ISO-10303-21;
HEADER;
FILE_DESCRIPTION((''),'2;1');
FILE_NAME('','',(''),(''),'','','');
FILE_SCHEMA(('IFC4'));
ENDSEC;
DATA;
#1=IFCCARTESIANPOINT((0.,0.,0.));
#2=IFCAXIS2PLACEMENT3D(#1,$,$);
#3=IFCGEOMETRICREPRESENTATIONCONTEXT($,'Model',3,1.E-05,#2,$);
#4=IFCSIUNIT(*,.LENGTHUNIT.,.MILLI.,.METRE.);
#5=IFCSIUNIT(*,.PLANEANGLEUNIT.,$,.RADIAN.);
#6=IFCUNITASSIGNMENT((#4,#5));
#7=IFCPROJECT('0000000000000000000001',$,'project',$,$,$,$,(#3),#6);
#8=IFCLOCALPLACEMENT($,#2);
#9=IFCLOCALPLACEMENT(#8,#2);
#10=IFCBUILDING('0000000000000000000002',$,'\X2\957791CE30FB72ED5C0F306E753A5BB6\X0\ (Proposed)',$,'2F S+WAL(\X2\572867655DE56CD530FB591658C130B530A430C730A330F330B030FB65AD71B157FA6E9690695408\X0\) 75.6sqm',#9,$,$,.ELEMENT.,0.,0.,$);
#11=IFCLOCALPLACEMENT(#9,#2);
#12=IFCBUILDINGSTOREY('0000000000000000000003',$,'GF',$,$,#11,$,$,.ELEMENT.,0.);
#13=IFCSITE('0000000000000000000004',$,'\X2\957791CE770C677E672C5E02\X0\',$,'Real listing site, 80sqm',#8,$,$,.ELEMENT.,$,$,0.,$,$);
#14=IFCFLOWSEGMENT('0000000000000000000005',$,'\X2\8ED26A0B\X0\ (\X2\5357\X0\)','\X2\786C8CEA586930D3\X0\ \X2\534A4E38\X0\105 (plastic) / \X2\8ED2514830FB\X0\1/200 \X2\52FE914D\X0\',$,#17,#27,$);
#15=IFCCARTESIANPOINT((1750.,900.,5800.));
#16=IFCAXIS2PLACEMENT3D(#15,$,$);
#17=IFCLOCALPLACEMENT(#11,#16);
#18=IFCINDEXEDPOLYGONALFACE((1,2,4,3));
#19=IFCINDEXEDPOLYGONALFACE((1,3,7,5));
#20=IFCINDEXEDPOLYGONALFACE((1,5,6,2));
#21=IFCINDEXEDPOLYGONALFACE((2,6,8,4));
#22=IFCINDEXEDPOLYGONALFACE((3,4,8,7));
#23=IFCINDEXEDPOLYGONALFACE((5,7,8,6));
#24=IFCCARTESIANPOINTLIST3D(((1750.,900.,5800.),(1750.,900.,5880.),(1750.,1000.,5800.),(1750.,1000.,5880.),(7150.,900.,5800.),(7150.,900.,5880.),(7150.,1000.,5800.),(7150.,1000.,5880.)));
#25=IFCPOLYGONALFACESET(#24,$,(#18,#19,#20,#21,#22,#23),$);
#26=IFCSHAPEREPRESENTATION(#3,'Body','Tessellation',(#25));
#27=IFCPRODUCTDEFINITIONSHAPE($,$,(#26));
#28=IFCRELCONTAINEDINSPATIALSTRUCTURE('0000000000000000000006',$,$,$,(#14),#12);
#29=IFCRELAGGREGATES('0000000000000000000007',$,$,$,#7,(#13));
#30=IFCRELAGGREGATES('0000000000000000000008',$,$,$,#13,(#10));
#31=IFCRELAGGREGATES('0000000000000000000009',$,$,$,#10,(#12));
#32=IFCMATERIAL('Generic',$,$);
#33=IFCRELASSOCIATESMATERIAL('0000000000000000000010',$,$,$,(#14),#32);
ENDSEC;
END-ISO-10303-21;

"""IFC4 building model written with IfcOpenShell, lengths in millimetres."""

from ifc_helpers import new_model, si_unit, frame, frame_2d, origin, place, context, project, spatial, rectangle, extrude, material, element, save


model = new_model("IFC4")

# Units and contexts
model_context = context("Model", 3, precision=1e-05, world=origin())
ifc_project = project(units=[si_unit("LENGTHUNIT", "METRE", prefix="MILLI"), si_unit("PLANEANGLEUNIT", "RADIAN")], contexts=[model_context])

# Site, building, storey
site_placement = place(None, origin())
site = spatial("IfcSite", under=ifc_project, at=site_placement, Name="長野県松本市", ObjectType="Real listing site, 80sqm", CompositionType="ELEMENT", RefElevation=0.0)
building_placement = place(site_placement, origin())
building = spatial("IfcBuilding", under=site, at=building_placement, Name="長野・狭小の町家 (Proposed)", ObjectType="2F S+WAL(在来工法・外壁サイディング・断熱基準適合) 75.6sqm", CompositionType="ELEMENT", ElevationOfRefHeight=0.0, ElevationOfTerrain=0.0)
storey_placement = place(building_placement, origin())
storey = spatial("IfcBuildingStorey", under=building, at=storey_placement, Name="GF", CompositionType="ELEMENT", Elevation=0.0)

# Flow segment
ifc_material_1 = material(Name="Generic")
flow_segment_placement = place(storey_placement, frame((1750.0, 900.0, 5800.0)))
element("IfcFlowSegment", 1, at=flow_segment_placement, inside=storey, material=ifc_material_1, Name="軒樋 (南)", Description="硬質塩ビ 半丸105 (plastic) / 軒先・1/200 勾配", context=model_context, shape_type="SweptSolid", body=[
    extrude(rectangle(XDim=5400.0, YDim=100.0, at=frame_2d((2700.0, 50.0))), frame((1750.0, 900.0, 5800.0)), (0.0, 0.0, 1.0), 80.0),
])

save(model, "model.ifc")
